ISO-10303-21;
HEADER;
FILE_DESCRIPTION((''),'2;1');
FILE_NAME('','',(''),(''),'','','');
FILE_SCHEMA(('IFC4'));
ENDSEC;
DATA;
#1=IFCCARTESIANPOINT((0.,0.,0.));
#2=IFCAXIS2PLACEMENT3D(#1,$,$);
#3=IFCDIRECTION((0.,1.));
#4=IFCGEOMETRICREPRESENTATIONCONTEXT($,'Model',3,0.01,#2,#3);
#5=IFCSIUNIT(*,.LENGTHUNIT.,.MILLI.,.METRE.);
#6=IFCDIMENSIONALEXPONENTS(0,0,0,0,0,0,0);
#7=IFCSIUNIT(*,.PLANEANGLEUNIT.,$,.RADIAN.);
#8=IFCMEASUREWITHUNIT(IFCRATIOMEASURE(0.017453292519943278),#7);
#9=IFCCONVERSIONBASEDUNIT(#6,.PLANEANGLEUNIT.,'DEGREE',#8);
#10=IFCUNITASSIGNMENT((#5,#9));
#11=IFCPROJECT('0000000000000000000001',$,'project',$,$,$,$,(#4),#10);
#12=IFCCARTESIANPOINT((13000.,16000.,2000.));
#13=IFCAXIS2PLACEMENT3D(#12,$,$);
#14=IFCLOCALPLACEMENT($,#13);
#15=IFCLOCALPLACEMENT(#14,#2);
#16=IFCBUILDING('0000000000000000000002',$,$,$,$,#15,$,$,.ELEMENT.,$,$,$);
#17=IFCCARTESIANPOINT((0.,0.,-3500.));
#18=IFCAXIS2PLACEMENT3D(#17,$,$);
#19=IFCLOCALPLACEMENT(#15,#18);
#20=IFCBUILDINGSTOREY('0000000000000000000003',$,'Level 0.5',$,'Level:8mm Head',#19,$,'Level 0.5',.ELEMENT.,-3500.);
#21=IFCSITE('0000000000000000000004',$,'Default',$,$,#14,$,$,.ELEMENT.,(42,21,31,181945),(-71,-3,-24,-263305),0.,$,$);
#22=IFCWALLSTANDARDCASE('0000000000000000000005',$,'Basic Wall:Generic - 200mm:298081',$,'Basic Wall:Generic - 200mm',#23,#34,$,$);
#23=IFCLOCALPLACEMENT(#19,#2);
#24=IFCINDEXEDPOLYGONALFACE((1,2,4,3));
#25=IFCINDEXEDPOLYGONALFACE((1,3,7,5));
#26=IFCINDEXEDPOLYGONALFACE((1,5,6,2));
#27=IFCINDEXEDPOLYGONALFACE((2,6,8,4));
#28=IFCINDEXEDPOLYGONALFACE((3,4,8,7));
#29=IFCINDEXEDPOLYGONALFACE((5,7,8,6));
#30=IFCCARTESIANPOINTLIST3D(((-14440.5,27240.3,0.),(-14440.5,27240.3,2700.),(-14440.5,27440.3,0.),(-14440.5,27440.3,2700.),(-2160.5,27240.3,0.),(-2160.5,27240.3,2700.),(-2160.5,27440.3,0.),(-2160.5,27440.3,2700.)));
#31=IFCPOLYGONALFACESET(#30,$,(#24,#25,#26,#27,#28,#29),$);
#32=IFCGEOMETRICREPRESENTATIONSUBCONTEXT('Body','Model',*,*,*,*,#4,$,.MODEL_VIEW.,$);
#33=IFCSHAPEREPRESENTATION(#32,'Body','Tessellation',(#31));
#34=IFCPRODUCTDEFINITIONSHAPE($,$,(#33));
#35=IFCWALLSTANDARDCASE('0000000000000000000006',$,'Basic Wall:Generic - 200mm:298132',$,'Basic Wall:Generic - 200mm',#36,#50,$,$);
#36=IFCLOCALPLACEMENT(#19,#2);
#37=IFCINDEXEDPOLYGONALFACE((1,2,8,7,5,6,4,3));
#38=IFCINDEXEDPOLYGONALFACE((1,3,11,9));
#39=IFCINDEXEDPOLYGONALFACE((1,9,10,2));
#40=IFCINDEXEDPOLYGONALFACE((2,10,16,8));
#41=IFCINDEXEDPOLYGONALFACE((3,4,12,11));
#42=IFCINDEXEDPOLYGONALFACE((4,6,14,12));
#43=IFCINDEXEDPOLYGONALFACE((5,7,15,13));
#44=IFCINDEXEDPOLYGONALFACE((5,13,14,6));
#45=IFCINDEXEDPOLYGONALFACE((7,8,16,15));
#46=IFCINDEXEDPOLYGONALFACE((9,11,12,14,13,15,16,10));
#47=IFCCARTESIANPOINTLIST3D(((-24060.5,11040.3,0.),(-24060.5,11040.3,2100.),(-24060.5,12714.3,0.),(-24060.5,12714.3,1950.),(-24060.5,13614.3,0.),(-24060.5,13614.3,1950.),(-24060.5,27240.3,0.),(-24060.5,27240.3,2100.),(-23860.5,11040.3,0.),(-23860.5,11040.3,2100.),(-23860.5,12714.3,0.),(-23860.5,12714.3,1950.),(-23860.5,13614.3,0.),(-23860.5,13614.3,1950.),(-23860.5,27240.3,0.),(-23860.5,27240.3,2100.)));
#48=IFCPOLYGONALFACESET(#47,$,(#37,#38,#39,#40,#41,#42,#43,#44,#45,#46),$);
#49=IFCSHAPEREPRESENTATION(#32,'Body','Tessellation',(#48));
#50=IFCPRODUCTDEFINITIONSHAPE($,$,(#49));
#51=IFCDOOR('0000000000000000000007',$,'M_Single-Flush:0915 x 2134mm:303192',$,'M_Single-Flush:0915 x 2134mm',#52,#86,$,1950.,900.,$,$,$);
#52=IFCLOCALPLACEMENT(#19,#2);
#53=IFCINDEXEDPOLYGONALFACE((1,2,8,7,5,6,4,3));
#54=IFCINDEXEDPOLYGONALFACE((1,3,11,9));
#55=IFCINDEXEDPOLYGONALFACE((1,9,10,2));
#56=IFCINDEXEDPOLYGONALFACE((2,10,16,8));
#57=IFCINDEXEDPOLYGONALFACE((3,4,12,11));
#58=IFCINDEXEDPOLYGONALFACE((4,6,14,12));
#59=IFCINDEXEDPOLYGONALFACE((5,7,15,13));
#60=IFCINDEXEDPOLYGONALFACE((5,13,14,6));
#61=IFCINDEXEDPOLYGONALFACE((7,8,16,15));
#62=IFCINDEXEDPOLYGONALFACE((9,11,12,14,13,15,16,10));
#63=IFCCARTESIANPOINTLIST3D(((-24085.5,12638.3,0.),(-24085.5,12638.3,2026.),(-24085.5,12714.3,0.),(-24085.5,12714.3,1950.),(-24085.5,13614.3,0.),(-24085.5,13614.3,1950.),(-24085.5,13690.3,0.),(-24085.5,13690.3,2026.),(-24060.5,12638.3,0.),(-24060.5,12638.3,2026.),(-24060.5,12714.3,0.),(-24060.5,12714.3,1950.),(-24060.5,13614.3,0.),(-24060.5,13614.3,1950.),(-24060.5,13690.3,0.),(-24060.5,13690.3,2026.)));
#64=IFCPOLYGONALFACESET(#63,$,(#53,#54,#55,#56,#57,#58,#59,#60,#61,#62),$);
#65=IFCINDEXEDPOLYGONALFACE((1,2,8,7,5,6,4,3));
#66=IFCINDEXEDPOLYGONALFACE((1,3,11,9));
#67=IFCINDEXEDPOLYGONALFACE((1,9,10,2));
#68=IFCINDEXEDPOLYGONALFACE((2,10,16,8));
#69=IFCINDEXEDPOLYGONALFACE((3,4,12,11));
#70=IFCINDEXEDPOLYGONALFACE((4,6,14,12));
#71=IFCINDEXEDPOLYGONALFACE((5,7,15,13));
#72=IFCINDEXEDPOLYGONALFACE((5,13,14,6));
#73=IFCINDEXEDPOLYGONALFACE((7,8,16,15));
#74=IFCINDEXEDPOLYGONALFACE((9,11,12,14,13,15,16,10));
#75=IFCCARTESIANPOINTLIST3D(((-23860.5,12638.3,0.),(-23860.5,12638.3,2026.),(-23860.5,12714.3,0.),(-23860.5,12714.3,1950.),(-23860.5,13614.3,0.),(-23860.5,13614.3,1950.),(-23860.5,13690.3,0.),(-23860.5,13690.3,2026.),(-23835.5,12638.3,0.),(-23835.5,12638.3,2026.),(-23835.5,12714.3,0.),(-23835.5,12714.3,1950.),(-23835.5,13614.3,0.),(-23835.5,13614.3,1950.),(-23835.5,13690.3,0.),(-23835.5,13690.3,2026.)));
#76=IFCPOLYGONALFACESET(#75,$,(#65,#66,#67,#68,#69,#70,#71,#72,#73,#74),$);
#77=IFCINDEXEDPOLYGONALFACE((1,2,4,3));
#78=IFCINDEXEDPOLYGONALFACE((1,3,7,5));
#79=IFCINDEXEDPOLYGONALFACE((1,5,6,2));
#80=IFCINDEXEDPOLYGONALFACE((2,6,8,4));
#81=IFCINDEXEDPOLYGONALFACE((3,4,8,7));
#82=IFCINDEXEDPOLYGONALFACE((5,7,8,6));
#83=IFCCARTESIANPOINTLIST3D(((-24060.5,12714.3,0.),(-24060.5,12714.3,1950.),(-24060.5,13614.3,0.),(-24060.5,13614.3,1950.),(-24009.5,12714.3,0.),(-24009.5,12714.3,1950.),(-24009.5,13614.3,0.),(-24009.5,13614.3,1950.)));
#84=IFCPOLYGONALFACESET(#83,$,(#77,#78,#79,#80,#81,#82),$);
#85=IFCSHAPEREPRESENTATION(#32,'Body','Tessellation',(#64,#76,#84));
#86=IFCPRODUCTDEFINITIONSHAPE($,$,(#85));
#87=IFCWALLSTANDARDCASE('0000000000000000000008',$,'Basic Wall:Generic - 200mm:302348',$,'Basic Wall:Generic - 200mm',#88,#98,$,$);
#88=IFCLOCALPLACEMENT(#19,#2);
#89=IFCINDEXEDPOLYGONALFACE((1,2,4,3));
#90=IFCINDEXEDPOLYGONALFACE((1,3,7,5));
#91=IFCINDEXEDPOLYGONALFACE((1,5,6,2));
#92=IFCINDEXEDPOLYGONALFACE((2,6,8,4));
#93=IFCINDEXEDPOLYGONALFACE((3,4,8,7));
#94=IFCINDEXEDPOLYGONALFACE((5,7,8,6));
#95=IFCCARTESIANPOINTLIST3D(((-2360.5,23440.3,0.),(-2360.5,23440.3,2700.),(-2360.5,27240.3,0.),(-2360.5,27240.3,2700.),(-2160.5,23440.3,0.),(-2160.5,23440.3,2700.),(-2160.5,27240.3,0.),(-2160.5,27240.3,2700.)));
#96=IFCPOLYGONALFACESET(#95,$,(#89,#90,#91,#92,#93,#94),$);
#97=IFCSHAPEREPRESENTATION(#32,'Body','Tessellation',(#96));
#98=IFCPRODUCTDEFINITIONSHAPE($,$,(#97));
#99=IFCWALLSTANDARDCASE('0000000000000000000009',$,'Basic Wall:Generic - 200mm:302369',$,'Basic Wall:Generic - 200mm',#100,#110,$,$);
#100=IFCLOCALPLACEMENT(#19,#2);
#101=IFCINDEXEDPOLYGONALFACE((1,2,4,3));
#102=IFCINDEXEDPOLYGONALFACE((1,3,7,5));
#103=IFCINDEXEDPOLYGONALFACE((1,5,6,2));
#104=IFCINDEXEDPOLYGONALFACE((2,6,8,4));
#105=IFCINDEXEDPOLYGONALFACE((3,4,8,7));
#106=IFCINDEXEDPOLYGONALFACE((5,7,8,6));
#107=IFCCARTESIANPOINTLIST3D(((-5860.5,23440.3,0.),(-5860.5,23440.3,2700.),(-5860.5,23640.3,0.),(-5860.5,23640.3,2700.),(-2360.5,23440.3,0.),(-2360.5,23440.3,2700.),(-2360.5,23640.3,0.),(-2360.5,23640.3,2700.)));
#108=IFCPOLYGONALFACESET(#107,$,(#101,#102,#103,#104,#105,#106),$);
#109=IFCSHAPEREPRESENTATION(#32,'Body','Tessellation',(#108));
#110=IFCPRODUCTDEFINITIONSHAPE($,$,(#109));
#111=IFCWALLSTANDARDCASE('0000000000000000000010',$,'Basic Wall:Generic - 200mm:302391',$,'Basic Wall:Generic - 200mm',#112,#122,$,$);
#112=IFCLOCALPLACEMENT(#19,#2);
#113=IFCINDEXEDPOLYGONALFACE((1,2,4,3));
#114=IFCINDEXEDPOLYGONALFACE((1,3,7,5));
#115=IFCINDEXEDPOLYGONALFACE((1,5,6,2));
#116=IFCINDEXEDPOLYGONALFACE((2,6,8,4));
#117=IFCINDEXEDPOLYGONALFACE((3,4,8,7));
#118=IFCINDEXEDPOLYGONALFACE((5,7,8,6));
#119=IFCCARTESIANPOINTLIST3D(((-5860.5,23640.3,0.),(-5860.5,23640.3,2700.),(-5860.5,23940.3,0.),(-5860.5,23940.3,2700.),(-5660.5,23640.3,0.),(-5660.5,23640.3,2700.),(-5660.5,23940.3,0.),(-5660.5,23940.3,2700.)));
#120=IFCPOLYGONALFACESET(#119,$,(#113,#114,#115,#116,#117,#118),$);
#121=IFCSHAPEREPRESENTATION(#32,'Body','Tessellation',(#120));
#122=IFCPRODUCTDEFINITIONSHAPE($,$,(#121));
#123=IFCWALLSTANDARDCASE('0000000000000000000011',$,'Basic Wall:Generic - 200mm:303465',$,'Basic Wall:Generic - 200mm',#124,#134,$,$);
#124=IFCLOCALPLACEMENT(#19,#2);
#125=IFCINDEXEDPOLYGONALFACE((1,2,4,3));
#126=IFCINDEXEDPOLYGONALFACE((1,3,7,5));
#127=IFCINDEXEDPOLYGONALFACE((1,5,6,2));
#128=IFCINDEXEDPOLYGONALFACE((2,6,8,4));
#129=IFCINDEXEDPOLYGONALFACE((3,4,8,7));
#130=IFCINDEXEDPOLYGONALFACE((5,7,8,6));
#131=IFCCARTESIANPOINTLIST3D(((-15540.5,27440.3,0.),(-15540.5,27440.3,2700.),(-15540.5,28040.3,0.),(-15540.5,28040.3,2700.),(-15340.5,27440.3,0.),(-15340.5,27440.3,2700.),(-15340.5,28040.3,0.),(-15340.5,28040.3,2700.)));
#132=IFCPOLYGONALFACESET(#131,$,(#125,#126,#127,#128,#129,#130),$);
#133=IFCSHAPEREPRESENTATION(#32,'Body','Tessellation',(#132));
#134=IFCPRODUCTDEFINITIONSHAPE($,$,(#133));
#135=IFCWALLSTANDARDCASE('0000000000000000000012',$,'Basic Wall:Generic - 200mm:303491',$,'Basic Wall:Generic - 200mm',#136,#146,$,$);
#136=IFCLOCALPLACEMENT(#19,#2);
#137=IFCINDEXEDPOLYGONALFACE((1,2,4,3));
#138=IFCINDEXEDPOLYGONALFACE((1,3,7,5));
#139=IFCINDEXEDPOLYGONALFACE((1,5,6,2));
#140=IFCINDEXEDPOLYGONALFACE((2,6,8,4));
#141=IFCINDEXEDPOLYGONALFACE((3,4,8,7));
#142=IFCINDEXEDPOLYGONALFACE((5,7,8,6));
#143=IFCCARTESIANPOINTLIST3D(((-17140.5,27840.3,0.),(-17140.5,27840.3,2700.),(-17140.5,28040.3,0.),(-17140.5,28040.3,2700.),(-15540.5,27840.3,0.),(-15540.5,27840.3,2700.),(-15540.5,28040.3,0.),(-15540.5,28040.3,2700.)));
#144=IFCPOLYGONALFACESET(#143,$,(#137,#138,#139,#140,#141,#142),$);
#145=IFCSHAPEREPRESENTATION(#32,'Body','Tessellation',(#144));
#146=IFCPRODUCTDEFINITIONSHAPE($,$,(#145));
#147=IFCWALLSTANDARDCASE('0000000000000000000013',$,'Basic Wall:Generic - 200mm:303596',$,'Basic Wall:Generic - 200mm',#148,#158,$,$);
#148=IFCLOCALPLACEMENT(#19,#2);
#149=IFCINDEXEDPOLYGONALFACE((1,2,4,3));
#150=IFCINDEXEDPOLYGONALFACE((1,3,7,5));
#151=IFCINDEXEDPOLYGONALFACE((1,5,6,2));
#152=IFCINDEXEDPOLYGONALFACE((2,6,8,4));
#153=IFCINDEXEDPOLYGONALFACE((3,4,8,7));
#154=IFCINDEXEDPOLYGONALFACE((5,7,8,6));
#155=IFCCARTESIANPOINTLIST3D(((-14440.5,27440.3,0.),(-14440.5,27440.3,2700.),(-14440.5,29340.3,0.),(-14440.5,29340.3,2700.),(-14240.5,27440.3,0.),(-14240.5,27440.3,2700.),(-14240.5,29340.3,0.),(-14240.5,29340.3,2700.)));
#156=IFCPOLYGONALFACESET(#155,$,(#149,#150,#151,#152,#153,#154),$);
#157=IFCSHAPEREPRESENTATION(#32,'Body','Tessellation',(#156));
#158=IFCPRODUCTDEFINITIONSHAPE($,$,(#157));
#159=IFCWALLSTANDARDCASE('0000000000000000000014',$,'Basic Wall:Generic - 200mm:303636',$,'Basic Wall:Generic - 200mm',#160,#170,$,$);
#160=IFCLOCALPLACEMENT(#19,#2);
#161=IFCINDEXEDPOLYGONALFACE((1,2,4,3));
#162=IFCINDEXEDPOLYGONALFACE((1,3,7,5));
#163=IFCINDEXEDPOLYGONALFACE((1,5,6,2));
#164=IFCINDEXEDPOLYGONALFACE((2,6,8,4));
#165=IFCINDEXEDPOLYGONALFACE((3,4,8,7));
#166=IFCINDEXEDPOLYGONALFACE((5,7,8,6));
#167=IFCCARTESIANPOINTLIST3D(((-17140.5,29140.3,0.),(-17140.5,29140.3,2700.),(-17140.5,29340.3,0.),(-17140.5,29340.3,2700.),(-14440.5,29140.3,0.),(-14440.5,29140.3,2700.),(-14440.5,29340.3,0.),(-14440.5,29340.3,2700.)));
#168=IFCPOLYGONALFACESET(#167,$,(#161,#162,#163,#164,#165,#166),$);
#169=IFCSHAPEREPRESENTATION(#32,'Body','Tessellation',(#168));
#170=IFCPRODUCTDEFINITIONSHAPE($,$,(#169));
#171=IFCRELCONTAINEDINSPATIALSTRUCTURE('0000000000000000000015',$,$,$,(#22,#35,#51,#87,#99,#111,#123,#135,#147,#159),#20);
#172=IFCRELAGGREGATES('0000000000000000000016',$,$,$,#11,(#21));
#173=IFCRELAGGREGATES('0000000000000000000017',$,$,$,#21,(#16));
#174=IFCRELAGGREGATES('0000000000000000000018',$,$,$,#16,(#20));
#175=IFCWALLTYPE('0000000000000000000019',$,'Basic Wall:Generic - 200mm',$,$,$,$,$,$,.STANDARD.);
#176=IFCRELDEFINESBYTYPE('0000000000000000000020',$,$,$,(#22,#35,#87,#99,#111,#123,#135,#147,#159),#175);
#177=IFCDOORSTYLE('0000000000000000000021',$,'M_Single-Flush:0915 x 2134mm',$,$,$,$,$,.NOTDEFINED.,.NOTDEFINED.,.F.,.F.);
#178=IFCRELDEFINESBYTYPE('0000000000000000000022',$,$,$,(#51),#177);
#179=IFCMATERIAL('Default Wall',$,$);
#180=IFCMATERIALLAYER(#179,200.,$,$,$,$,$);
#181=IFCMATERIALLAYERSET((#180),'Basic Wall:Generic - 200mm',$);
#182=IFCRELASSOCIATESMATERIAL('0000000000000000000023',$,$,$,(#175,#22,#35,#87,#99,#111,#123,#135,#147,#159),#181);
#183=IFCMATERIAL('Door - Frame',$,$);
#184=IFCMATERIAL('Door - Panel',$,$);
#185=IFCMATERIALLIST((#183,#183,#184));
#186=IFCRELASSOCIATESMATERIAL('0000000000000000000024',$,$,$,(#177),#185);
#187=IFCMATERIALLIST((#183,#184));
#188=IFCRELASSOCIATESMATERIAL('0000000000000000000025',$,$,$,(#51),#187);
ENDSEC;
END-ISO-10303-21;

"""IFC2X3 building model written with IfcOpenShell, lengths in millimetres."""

from ifc_helpers import new_model, entity, si_unit, converted_unit, direction, frame, frame_2d, origin, place, context, subcontext, project, spatial, polyline, rectangle, outline, extrude, clip, bounded_halfspace, source, transform, mapped, material, material_list, layer, layer_set, layer_usage, type_object, type_shapes, element, fill, save


model = new_model("IFC2X3")

# Units and contexts
model_context = context("Model", 3, precision=0.01, world=origin(), true_north=direction((0.0, 1.0)))
body_context = subcontext(model_context, "Body", "Model", "MODEL_VIEW")
ifc_project = project(units=[si_unit("LENGTHUNIT", "METRE", prefix="MILLI"), converted_unit("PLANEANGLEUNIT", "DEGREE", entity("IfcRatioMeasure", 0.017453292519943278), si_unit("PLANEANGLEUNIT", "RADIAN"), dimensions=[0, 0, 0, 0, 0, 0, 0])], contexts=[model_context])

# Site, building, storey
site_placement = place(None, frame((13000.0, 16000.0, 2000.0)))
site = spatial("IfcSite", under=ifc_project, at=site_placement, Name="Default", CompositionType="ELEMENT", RefLatitude=(42, 21, 31, 181945), RefLongitude=(-71, -3, -24, -263305), RefElevation=0.0)
building_placement = place(site_placement, origin())
building = spatial("IfcBuilding", under=site, at=building_placement, CompositionType="ELEMENT")
storey_placement = place(building_placement, frame((0.0, 0.0, -3500.0)))
storey = spatial("IfcBuildingStorey", under=building, at=storey_placement, Name="Level 0.5", ObjectType="Level:8mm Head", LongName="Level 0.5", CompositionType="ELEMENT", Elevation=-3500.0)

# Wall
ifc_material_1 = material(Name="Default Wall")
ifc_layer_1 = layer(ifc_material_1, 200.0)
ifc_layer_set_1 = layer_set([ifc_layer_1], Name="Basic Wall:Generic - 200mm")
wall_type_1 = type_object("IfcWallType", Name="Basic Wall:Generic - 200mm", PredefinedType="STANDARD", material=ifc_layer_set_1)
ifc_layer_usage_1 = layer_usage(ifc_layer_set_1, "AXIS2", "NEGATIVE", 100.0)
wall_1_placement = place(storey_placement, frame((-2160.5, 27340.3, 0.0), z_axis=(0.0, 0.0, 1.0), x_axis=(-1.0, 0.0, 0.0)))
element("IfcWallStandardCase", 1, at=wall_1_placement, inside=storey, type_object=wall_type_1, material=ifc_layer_usage_1, Name="Basic Wall:Generic - 200mm:298081", ObjectType="Basic Wall:Generic - 200mm", context=body_context, shape_type="SweptSolid", body=[
    extrude(rectangle(XDim=12280.0, YDim=200.0, at=frame_2d((6140.0, 0.0), x_axis=(-1.0, 0.0))), origin(), (0.0, 0.0, 1.0), 2700.0),
])

# Wall, opening, door
ifc_layer_usage_2 = layer_usage(ifc_layer_set_1, "AXIS2", "NEGATIVE", 100.0)
wall_2_placement = place(storey_placement, frame((-23960.5, 27240.3, 0.0), z_axis=(0.0, 0.0, 1.0), x_axis=(0.0, -1.0, 0.0)))
wall_2 = element("IfcWallStandardCase", 2, at=wall_2_placement, inside=storey, type_object=wall_type_1, material=ifc_layer_usage_2, Name="Basic Wall:Generic - 200mm:298132", ObjectType="Basic Wall:Generic - 200mm", context=body_context, shape_type="Clipping", body=[
    clip(extrude(rectangle(XDim=16200.0, YDim=200.0, at=frame_2d((8100.0, 0.0), x_axis=(1.0, 0.0))), origin(), (0.0, 0.0, 1.0), 2100.0), bounded_halfspace(frame((0.0, -100.0, 2100.0), z_axis=(0.0, 0.0, -1.0), x_axis=(1.0, 0.0, 0.0)), True, frame((0.0, -100.0, 2100.0)), polyline([(0.0, 0.0), (4884716.1, 0.0), (4937760.0, 0.0), (4937760.0, 60960.0), (0.0, 60960.0), (0.0, 0.0)]))),
])
opening_1_placement = place(wall_2_placement, frame((14526.0, 100.0, 0.0)))
opening_1 = element("IfcOpeningElement", 3, at=opening_1_placement, cuts=wall_2, ObjectType="Opening", context=body_context, shape_type="SweptSolid", body=[
    extrude(rectangle(XDim=900.0, YDim=1950.0, at=frame_2d((975.0, 450.0), x_axis=(0.0, -1.0))), frame((0.0, 0.0, 0.0), z_axis=(0.0, -1.0, 0.0), x_axis=(0.0, 0.0, 1.0)), (0.0, 0.0, 1.0), 200.0),
])
ifc_material_2 = material(Name="Door - Frame")
ifc_material_3 = material(Name="Door - Panel")
ifc_material_list_1 = material_list([ifc_material_2, ifc_material_3])
ifc_material_list_2 = material_list([ifc_material_2, ifc_material_2, ifc_material_3])
door_style = type_object("IfcDoorStyle", Name="M_Single-Flush:0915 x 2134mm", ConstructionType="NOTDEFINED", OperationType="NOTDEFINED", ParameterTakesPrecedence=False, Sizeable=False, material=ifc_material_list_2)
shared_shape_1 = source(origin(), body_context, "Body", "SweptSolid", [
    extrude(outline(polyline([(-526.0, -1032.0), (526.0, -1032.0), (526.0, 994.0), (450.0, 994.0), (450.0, -956.0), (-450.0, -956.0), (-450.0, 994.0), (-526.0, 994.0), (-526.0, -1032.0)])), frame((450.0, 225.0, 994.0), z_axis=(0.0, -1.0, 0.0), x_axis=(-1.0, 0.0, 0.0)), (0.0, 0.0, 1.0), 25.0),
    extrude(outline(polyline([(-1032.0, -526.0), (994.0, -526.0), (994.0, -450.0), (-956.0, -450.0), (-956.0, 450.0), (994.0, 450.0), (994.0, 526.0), (-1032.0, 526.0), (-1032.0, -526.0)])), frame((450.0, 0.0, 994.0), z_axis=(0.0, -1.0, 0.0), x_axis=(0.0, 0.0, -1.0)), (0.0, 0.0, 1.0), 25.0),
    extrude(rectangle(XDim=900.0, YDim=51.0, at=frame_2d((0.0, 0.0), x_axis=(1.0, 0.0))), frame((450.0, 174.5, 0.0)), (0.0, 0.0, 1.0), 1950.0),
])
type_shapes(door_style, [shared_shape_1])
door_placement = place(opening_1_placement, frame((0.0, 0.0, 0.0), z_axis=(0.0, 0.0, 1.0), x_axis=(-1.0, 0.0, 0.0)))
door = element("IfcDoor", 4, at=door_placement, inside=storey, type_object=door_style, material=ifc_material_list_1, Name="M_Single-Flush:0915 x 2134mm:303192", ObjectType="M_Single-Flush:0915 x 2134mm", OverallHeight=1950.0, OverallWidth=900.0, context=body_context, shape_type="MappedRepresentation", body=[
    mapped(shared_shape_1, transform((0.0, 0.0, 0.0), scale=1.0)),
])
fill(opening_1, door)

# Walls
ifc_layer_usage_3 = layer_usage(ifc_layer_set_1, "AXIS2", "NEGATIVE", 100.0)
wall_3_placement = place(storey_placement, frame((-2260.5, 27240.3, 0.0), z_axis=(0.0, 0.0, 1.0), x_axis=(0.0, -1.0, 0.0)))
element("IfcWallStandardCase", 5, at=wall_3_placement, inside=storey, type_object=wall_type_1, material=ifc_layer_usage_3, Name="Basic Wall:Generic - 200mm:302348", ObjectType="Basic Wall:Generic - 200mm", context=body_context, shape_type="SweptSolid", body=[
    extrude(rectangle(XDim=3800.0, YDim=200.0, at=frame_2d((1900.0, 0.0), x_axis=(-1.0, 0.0))), origin(), (0.0, 0.0, 1.0), 2700.0),
])
ifc_layer_usage_4 = layer_usage(ifc_layer_set_1, "AXIS2", "NEGATIVE", 100.0)
wall_4_placement = place(storey_placement, frame((-2360.5, 23540.3, 0.0), z_axis=(0.0, 0.0, 1.0), x_axis=(-1.0, 0.0, 0.0)))
element("IfcWallStandardCase", 6, at=wall_4_placement, inside=storey, type_object=wall_type_1, material=ifc_layer_usage_4, Name="Basic Wall:Generic - 200mm:302369", ObjectType="Basic Wall:Generic - 200mm", context=body_context, shape_type="SweptSolid", body=[
    extrude(rectangle(XDim=3500.0, YDim=200.0, at=frame_2d((1750.0, 0.0), x_axis=(-1.0, 0.0))), origin(), (0.0, 0.0, 1.0), 2700.0),
])
ifc_layer_usage_5 = layer_usage(ifc_layer_set_1, "AXIS2", "NEGATIVE", 100.0)
wall_5_placement = place(storey_placement, frame((-5760.5, 23640.3, 0.0), z_axis=(0.0, 0.0, 1.0), x_axis=(0.0, 1.0, 0.0)))
element("IfcWallStandardCase", 7, at=wall_5_placement, inside=storey, type_object=wall_type_1, material=ifc_layer_usage_5, Name="Basic Wall:Generic - 200mm:302391", ObjectType="Basic Wall:Generic - 200mm", context=body_context, shape_type="SweptSolid", body=[
    extrude(rectangle(XDim=300.0, YDim=200.0, at=frame_2d((150.0, 0.0), x_axis=(-1.0, 0.0))), origin(), (0.0, 0.0, 1.0), 2700.0),
])
ifc_layer_usage_6 = layer_usage(ifc_layer_set_1, "AXIS2", "NEGATIVE", 100.0)
wall_6_placement = place(storey_placement, frame((-15440.5, 27440.3, 0.0), z_axis=(0.0, 0.0, 1.0), x_axis=(0.0, 1.0, 0.0)))
element("IfcWallStandardCase", 8, at=wall_6_placement, inside=storey, type_object=wall_type_1, material=ifc_layer_usage_6, Name="Basic Wall:Generic - 200mm:303465", ObjectType="Basic Wall:Generic - 200mm", context=body_context, shape_type="SweptSolid", body=[
    extrude(rectangle(XDim=600.0, YDim=200.0, at=frame_2d((300.0, 0.0), x_axis=(-1.0, 0.0))), origin(), (0.0, 0.0, 1.0), 2700.0),
])
ifc_layer_usage_7 = layer_usage(ifc_layer_set_1, "AXIS2", "NEGATIVE", 100.0)
wall_7_placement = place(storey_placement, frame((-15540.5, 27940.3, 0.0), z_axis=(0.0, 0.0, 1.0), x_axis=(-1.0, 0.0, 0.0)))
element("IfcWallStandardCase", 9, at=wall_7_placement, inside=storey, type_object=wall_type_1, material=ifc_layer_usage_7, Name="Basic Wall:Generic - 200mm:303491", ObjectType="Basic Wall:Generic - 200mm", context=body_context, shape_type="SweptSolid", body=[
    extrude(rectangle(XDim=1600.0, YDim=200.0, at=frame_2d((800.0, 0.0), x_axis=(-1.0, 0.0))), origin(), (0.0, 0.0, 1.0), 2700.0),
])
ifc_layer_usage_8 = layer_usage(ifc_layer_set_1, "AXIS2", "NEGATIVE", 100.0)
wall_8_placement = place(storey_placement, frame((-14340.5, 27440.3, 0.0), z_axis=(0.0, 0.0, 1.0), x_axis=(0.0, 1.0, 0.0)))
element("IfcWallStandardCase", 10, at=wall_8_placement, inside=storey, type_object=wall_type_1, material=ifc_layer_usage_8, Name="Basic Wall:Generic - 200mm:303596", ObjectType="Basic Wall:Generic - 200mm", context=body_context, shape_type="SweptSolid", body=[
    extrude(rectangle(XDim=1900.0, YDim=200.0, at=frame_2d((950.0, 0.0), x_axis=(-1.0, 0.0))), origin(), (0.0, 0.0, 1.0), 2700.0),
])
ifc_layer_usage_9 = layer_usage(ifc_layer_set_1, "AXIS2", "NEGATIVE", 100.0)
wall_9_placement = place(storey_placement, frame((-14440.5, 29240.3, 0.0), z_axis=(0.0, 0.0, 1.0), x_axis=(-1.0, 0.0, 0.0)))
element("IfcWallStandardCase", 11, at=wall_9_placement, inside=storey, type_object=wall_type_1, material=ifc_layer_usage_9, Name="Basic Wall:Generic - 200mm:303636", ObjectType="Basic Wall:Generic - 200mm", context=body_context, shape_type="SweptSolid", body=[
    extrude(rectangle(XDim=2700.0, YDim=200.0, at=frame_2d((1350.0, 0.0), x_axis=(-1.0, 0.0))), origin(), (0.0, 0.0, 1.0), 2700.0),
])

save(model, "model.ifc")
